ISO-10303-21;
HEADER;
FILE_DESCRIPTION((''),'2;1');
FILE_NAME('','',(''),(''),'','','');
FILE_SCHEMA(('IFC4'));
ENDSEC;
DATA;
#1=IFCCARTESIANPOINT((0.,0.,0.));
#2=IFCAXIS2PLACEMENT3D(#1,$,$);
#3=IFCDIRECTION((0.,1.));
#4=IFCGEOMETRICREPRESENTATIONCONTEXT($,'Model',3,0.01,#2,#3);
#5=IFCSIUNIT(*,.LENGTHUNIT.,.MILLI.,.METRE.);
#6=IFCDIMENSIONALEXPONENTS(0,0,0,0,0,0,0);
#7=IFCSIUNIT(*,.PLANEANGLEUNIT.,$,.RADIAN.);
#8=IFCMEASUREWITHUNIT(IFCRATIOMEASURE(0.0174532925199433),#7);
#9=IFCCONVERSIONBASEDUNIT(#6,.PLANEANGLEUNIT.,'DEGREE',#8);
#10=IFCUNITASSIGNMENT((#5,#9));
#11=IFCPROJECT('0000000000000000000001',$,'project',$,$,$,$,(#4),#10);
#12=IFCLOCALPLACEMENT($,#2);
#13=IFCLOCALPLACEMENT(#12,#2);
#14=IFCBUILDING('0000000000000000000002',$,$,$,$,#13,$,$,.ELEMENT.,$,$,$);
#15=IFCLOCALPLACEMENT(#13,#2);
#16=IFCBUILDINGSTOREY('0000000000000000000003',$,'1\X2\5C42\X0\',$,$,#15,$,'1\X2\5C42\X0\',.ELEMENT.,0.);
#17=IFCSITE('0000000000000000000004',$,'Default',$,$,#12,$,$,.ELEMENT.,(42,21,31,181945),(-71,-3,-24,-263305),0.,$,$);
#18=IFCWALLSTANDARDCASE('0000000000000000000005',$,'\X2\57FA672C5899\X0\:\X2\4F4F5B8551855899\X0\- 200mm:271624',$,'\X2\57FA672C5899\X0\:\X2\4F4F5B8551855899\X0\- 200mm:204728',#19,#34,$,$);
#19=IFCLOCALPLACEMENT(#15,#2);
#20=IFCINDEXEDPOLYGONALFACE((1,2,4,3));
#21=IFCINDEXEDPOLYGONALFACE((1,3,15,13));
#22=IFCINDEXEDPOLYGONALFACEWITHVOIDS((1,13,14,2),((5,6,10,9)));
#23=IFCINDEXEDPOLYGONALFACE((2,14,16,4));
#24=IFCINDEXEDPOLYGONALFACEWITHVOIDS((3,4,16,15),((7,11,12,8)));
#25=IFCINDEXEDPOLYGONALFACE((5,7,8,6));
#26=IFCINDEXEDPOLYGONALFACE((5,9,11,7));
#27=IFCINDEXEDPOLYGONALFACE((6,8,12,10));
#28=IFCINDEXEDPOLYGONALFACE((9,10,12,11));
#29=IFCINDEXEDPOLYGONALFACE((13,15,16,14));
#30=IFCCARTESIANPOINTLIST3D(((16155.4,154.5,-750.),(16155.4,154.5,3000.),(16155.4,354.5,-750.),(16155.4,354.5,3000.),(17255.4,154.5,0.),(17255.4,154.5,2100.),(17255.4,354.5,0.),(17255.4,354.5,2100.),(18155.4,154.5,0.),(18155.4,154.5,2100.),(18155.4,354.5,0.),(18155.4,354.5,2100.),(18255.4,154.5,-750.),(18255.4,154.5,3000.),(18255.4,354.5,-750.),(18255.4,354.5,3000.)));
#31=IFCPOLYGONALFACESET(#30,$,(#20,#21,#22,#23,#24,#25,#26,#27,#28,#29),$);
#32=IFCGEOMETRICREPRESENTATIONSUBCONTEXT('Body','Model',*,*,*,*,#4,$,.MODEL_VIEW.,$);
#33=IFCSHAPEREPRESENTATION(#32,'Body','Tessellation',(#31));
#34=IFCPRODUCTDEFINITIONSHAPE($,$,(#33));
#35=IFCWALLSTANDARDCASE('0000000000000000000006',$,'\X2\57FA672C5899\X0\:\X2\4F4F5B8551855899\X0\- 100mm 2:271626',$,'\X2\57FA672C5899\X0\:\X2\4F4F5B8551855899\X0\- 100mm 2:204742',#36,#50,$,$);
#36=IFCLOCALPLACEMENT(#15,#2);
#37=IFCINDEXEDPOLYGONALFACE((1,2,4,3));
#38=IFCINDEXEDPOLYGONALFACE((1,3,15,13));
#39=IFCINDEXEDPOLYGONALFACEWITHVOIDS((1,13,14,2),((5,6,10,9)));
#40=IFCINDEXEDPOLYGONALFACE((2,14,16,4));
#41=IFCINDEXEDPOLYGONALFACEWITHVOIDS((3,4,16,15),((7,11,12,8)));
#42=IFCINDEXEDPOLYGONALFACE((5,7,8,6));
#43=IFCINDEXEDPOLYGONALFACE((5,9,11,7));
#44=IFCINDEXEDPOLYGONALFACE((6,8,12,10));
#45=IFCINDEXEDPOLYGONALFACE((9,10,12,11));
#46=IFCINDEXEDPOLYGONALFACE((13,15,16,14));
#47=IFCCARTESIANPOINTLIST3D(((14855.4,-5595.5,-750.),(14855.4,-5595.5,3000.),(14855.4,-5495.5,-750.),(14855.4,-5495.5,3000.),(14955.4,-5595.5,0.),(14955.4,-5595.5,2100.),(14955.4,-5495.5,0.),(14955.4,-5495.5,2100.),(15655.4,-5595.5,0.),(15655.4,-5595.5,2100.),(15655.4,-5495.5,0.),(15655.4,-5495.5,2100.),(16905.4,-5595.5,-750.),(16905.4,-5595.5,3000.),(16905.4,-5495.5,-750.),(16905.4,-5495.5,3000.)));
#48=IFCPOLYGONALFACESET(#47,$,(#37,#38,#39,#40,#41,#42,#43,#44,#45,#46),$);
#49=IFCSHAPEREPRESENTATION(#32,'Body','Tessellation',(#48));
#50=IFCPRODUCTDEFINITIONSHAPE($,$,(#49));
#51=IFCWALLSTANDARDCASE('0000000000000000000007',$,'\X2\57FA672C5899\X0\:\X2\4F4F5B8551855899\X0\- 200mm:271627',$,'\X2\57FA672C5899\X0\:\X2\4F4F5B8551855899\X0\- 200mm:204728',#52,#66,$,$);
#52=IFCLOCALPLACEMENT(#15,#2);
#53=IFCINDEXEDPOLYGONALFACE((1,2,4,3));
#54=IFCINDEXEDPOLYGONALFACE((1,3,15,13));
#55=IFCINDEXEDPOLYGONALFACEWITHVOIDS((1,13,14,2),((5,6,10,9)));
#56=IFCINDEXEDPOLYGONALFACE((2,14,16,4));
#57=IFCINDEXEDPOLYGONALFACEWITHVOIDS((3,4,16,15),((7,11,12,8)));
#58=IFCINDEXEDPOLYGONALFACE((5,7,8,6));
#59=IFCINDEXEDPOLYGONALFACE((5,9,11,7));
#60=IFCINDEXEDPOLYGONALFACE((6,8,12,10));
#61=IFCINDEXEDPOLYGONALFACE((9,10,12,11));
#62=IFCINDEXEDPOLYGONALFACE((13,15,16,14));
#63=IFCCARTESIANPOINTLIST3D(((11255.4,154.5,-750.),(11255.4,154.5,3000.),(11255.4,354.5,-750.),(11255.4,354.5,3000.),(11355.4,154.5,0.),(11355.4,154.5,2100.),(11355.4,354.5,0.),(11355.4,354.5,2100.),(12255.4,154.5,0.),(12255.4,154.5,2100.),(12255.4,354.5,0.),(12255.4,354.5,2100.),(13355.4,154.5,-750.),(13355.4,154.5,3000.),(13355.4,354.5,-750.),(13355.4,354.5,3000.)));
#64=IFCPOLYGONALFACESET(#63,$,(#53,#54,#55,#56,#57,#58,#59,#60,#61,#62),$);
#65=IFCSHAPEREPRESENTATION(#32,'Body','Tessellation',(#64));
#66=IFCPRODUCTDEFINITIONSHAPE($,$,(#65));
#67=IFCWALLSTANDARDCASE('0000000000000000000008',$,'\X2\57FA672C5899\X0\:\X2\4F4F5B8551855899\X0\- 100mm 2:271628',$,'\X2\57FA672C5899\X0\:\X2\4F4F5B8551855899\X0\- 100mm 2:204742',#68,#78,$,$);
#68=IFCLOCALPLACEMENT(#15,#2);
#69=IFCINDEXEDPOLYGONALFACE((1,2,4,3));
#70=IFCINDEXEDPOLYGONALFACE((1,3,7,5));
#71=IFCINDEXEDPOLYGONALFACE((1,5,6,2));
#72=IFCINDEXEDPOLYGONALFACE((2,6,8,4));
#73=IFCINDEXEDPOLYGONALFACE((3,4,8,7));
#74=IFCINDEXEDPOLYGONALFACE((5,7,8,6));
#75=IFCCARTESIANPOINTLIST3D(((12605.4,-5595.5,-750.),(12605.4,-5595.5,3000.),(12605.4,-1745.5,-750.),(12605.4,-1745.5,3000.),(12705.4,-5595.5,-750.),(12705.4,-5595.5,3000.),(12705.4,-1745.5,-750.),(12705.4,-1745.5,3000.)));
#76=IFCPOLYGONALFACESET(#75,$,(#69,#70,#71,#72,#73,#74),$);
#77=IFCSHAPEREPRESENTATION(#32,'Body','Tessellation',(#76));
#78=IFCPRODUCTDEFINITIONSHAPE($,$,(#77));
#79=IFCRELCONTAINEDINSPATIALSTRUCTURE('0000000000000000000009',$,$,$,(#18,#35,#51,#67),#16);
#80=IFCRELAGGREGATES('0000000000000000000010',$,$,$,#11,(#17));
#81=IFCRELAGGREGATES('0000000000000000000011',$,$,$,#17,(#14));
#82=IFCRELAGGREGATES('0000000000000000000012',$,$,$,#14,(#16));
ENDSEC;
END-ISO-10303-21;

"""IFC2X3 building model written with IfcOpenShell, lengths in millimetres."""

from ifc_helpers import new_model, entity, si_unit, converted_unit, direction, frame, frame_2d, origin, place, context, subcontext, project, spatial, rectangle, extrude, element, save


model = new_model("IFC2X3")

# Units and contexts
model_context = context("Model", 3, precision=0.01, world=origin(), true_north=direction((0.0, 1.0)))
body_context = subcontext(model_context, "Body", "Model", "MODEL_VIEW")
ifc_project = project(units=[si_unit("LENGTHUNIT", "METRE", prefix="MILLI"), converted_unit("PLANEANGLEUNIT", "DEGREE", entity("IfcRatioMeasure", 0.0174532925199433), si_unit("PLANEANGLEUNIT", "RADIAN"), dimensions=[0, 0, 0, 0, 0, 0, 0])], contexts=[model_context])

# Site, building, storey
site_placement = place(None, origin())
site = spatial("IfcSite", under=ifc_project, at=site_placement, Name="Default", CompositionType="ELEMENT", RefLatitude=(42, 21, 31, 181945), RefLongitude=(-71, -3, -24, -263305), RefElevation=0.0)
building_placement = place(site_placement, origin())
building = spatial("IfcBuilding", under=site, at=building_placement, CompositionType="ELEMENT")
storey_placement = place(building_placement, origin())
storey = spatial("IfcBuildingStorey", under=building, at=storey_placement, Name="1层", LongName="1层", CompositionType="ELEMENT", Elevation=0.0)

# Wall, opening
wall_1_placement = place(storey_placement, frame((18255.4, 254.5, -750.0), z_axis=(0.0, 0.0, 1.0), x_axis=(-1.0, 0.0, 0.0)))
wall_1 = element("IfcWallStandardCase", 1, at=wall_1_placement, inside=storey, Name="基本墙:住宅内墙- 200mm:271624", ObjectType="基本墙:住宅内墙- 200mm:204728", context=body_context, shape_type="SweptSolid", body=[
    extrude(rectangle(XDim=2100.0, YDim=200.0, at=frame_2d((1050.0, 0.0), x_axis=(-1.0, 0.0))), origin(), (0.0, 0.0, 1.0), 3750.0),
])
opening_1_placement = place(wall_1_placement, frame((1000.0, 100.0, 750.0)))
element("IfcOpeningElement", 2, at=opening_1_placement, cuts=wall_1, ObjectType="Opening", context=body_context, shape_type="SweptSolid", body=[
    extrude(rectangle(XDim=2100.0, YDim=900.0, at=frame_2d((1050.0, 450.0), x_axis=(1.0, 0.0))), frame((0.0, 0.0, 0.0), z_axis=(0.0, -1.0, 0.0), x_axis=(0.0, 0.0, 1.0)), (0.0, 0.0, 1.0), 200.0),
])

# Wall, openings
wall_2_placement = place(storey_placement, frame((16905.4, -5545.5, -750.0), z_axis=(0.0, 0.0, 1.0), x_axis=(-1.0, 0.0, 0.0)))
wall_2 = element("IfcWallStandardCase", 3, at=wall_2_placement, inside=storey, Name="基本墙:住宅内墙- 100mm 2:271626", ObjectType="基本墙:住宅内墙- 100mm 2:204742", context=body_context, shape_type="SweptSolid", body=[
    extrude(rectangle(XDim=2050.0, YDim=100.0, at=frame_2d((1025.0, 0.0), x_axis=(-1.0, 0.0))), origin(), (0.0, 0.0, 1.0), 3750.0),
])
opening_2_placement = place(wall_2_placement, frame((1950.0, 50.0, 750.0)))
element("IfcOpeningElement", 4, at=opening_2_placement, cuts=wall_2, ObjectType="Opening", context=body_context, shape_type="SweptSolid", body=[
    extrude(rectangle(XDim=2100.0, YDim=700.0, at=frame_2d((1050.0, 350.0), x_axis=(1.0, 0.0))), frame((0.0, 0.0, 0.0), z_axis=(0.0, -1.0, 0.0), x_axis=(0.0, 0.0, 1.0)), (0.0, 0.0, 1.0), 100.0),
])
opening_3_placement = place(wall_2_placement, origin())
element("IfcOpeningElement", 5, at=opening_3_placement, cuts=wall_2, ObjectType="Opening", context=body_context, shape_type="SweptSolid", body=[
    extrude(rectangle(XDim=2100.0, YDim=700.0, at=frame_2d((0.0, 0.0), x_axis=(0.0, 1.0))), frame((1600.0, -1474.0, 4800.0), z_axis=(0.0, 1.0, 0.0), x_axis=(-1.0, 0.0, 0.0)), (0.0, 0.0, 1.0), 3048.0),
])

# Wall, opening
wall_3_placement = place(storey_placement, frame((11255.4, 254.5, -750.0)))
wall_3 = element("IfcWallStandardCase", 6, at=wall_3_placement, inside=storey, Name="基本墙:住宅内墙- 200mm:271627", ObjectType="基本墙:住宅内墙- 200mm:204728", context=body_context, shape_type="SweptSolid", body=[
    extrude(rectangle(XDim=2100.0, YDim=200.0, at=frame_2d((1050.0, 0.0), x_axis=(-1.0, 0.0))), origin(), (0.0, 0.0, 1.0), 3750.0),
])
opening_4_placement = place(wall_3_placement, frame((100.0, -100.0, 750.0)))
element("IfcOpeningElement", 7, at=opening_4_placement, cuts=wall_3, ObjectType="Opening", context=body_context, shape_type="SweptSolid", body=[
    extrude(rectangle(XDim=2100.0, YDim=900.0, at=frame_2d((1050.0, 450.0), x_axis=(1.0, 0.0))), frame((0.0, 0.0, 0.0), z_axis=(0.0, 1.0, 0.0), x_axis=(0.0, 0.0, 1.0)), (0.0, 0.0, 1.0), 200.0),
])

# Wall
wall_4_placement = place(storey_placement, frame((12655.4, -1745.5, -750.0), z_axis=(0.0, 0.0, 1.0), x_axis=(0.0, -1.0, 0.0)))
element("IfcWallStandardCase", 8, at=wall_4_placement, inside=storey, Name="基本墙:住宅内墙- 100mm 2:271628", ObjectType="基本墙:住宅内墙- 100mm 2:204742", context=body_context, shape_type="SweptSolid", body=[
    extrude(rectangle(XDim=3850.0, YDim=100.0, at=frame_2d((1925.0, 0.0), x_axis=(-1.0, 0.0))), origin(), (0.0, 0.0, 1.0), 3750.0),
])

save(model, "model.ifc")
